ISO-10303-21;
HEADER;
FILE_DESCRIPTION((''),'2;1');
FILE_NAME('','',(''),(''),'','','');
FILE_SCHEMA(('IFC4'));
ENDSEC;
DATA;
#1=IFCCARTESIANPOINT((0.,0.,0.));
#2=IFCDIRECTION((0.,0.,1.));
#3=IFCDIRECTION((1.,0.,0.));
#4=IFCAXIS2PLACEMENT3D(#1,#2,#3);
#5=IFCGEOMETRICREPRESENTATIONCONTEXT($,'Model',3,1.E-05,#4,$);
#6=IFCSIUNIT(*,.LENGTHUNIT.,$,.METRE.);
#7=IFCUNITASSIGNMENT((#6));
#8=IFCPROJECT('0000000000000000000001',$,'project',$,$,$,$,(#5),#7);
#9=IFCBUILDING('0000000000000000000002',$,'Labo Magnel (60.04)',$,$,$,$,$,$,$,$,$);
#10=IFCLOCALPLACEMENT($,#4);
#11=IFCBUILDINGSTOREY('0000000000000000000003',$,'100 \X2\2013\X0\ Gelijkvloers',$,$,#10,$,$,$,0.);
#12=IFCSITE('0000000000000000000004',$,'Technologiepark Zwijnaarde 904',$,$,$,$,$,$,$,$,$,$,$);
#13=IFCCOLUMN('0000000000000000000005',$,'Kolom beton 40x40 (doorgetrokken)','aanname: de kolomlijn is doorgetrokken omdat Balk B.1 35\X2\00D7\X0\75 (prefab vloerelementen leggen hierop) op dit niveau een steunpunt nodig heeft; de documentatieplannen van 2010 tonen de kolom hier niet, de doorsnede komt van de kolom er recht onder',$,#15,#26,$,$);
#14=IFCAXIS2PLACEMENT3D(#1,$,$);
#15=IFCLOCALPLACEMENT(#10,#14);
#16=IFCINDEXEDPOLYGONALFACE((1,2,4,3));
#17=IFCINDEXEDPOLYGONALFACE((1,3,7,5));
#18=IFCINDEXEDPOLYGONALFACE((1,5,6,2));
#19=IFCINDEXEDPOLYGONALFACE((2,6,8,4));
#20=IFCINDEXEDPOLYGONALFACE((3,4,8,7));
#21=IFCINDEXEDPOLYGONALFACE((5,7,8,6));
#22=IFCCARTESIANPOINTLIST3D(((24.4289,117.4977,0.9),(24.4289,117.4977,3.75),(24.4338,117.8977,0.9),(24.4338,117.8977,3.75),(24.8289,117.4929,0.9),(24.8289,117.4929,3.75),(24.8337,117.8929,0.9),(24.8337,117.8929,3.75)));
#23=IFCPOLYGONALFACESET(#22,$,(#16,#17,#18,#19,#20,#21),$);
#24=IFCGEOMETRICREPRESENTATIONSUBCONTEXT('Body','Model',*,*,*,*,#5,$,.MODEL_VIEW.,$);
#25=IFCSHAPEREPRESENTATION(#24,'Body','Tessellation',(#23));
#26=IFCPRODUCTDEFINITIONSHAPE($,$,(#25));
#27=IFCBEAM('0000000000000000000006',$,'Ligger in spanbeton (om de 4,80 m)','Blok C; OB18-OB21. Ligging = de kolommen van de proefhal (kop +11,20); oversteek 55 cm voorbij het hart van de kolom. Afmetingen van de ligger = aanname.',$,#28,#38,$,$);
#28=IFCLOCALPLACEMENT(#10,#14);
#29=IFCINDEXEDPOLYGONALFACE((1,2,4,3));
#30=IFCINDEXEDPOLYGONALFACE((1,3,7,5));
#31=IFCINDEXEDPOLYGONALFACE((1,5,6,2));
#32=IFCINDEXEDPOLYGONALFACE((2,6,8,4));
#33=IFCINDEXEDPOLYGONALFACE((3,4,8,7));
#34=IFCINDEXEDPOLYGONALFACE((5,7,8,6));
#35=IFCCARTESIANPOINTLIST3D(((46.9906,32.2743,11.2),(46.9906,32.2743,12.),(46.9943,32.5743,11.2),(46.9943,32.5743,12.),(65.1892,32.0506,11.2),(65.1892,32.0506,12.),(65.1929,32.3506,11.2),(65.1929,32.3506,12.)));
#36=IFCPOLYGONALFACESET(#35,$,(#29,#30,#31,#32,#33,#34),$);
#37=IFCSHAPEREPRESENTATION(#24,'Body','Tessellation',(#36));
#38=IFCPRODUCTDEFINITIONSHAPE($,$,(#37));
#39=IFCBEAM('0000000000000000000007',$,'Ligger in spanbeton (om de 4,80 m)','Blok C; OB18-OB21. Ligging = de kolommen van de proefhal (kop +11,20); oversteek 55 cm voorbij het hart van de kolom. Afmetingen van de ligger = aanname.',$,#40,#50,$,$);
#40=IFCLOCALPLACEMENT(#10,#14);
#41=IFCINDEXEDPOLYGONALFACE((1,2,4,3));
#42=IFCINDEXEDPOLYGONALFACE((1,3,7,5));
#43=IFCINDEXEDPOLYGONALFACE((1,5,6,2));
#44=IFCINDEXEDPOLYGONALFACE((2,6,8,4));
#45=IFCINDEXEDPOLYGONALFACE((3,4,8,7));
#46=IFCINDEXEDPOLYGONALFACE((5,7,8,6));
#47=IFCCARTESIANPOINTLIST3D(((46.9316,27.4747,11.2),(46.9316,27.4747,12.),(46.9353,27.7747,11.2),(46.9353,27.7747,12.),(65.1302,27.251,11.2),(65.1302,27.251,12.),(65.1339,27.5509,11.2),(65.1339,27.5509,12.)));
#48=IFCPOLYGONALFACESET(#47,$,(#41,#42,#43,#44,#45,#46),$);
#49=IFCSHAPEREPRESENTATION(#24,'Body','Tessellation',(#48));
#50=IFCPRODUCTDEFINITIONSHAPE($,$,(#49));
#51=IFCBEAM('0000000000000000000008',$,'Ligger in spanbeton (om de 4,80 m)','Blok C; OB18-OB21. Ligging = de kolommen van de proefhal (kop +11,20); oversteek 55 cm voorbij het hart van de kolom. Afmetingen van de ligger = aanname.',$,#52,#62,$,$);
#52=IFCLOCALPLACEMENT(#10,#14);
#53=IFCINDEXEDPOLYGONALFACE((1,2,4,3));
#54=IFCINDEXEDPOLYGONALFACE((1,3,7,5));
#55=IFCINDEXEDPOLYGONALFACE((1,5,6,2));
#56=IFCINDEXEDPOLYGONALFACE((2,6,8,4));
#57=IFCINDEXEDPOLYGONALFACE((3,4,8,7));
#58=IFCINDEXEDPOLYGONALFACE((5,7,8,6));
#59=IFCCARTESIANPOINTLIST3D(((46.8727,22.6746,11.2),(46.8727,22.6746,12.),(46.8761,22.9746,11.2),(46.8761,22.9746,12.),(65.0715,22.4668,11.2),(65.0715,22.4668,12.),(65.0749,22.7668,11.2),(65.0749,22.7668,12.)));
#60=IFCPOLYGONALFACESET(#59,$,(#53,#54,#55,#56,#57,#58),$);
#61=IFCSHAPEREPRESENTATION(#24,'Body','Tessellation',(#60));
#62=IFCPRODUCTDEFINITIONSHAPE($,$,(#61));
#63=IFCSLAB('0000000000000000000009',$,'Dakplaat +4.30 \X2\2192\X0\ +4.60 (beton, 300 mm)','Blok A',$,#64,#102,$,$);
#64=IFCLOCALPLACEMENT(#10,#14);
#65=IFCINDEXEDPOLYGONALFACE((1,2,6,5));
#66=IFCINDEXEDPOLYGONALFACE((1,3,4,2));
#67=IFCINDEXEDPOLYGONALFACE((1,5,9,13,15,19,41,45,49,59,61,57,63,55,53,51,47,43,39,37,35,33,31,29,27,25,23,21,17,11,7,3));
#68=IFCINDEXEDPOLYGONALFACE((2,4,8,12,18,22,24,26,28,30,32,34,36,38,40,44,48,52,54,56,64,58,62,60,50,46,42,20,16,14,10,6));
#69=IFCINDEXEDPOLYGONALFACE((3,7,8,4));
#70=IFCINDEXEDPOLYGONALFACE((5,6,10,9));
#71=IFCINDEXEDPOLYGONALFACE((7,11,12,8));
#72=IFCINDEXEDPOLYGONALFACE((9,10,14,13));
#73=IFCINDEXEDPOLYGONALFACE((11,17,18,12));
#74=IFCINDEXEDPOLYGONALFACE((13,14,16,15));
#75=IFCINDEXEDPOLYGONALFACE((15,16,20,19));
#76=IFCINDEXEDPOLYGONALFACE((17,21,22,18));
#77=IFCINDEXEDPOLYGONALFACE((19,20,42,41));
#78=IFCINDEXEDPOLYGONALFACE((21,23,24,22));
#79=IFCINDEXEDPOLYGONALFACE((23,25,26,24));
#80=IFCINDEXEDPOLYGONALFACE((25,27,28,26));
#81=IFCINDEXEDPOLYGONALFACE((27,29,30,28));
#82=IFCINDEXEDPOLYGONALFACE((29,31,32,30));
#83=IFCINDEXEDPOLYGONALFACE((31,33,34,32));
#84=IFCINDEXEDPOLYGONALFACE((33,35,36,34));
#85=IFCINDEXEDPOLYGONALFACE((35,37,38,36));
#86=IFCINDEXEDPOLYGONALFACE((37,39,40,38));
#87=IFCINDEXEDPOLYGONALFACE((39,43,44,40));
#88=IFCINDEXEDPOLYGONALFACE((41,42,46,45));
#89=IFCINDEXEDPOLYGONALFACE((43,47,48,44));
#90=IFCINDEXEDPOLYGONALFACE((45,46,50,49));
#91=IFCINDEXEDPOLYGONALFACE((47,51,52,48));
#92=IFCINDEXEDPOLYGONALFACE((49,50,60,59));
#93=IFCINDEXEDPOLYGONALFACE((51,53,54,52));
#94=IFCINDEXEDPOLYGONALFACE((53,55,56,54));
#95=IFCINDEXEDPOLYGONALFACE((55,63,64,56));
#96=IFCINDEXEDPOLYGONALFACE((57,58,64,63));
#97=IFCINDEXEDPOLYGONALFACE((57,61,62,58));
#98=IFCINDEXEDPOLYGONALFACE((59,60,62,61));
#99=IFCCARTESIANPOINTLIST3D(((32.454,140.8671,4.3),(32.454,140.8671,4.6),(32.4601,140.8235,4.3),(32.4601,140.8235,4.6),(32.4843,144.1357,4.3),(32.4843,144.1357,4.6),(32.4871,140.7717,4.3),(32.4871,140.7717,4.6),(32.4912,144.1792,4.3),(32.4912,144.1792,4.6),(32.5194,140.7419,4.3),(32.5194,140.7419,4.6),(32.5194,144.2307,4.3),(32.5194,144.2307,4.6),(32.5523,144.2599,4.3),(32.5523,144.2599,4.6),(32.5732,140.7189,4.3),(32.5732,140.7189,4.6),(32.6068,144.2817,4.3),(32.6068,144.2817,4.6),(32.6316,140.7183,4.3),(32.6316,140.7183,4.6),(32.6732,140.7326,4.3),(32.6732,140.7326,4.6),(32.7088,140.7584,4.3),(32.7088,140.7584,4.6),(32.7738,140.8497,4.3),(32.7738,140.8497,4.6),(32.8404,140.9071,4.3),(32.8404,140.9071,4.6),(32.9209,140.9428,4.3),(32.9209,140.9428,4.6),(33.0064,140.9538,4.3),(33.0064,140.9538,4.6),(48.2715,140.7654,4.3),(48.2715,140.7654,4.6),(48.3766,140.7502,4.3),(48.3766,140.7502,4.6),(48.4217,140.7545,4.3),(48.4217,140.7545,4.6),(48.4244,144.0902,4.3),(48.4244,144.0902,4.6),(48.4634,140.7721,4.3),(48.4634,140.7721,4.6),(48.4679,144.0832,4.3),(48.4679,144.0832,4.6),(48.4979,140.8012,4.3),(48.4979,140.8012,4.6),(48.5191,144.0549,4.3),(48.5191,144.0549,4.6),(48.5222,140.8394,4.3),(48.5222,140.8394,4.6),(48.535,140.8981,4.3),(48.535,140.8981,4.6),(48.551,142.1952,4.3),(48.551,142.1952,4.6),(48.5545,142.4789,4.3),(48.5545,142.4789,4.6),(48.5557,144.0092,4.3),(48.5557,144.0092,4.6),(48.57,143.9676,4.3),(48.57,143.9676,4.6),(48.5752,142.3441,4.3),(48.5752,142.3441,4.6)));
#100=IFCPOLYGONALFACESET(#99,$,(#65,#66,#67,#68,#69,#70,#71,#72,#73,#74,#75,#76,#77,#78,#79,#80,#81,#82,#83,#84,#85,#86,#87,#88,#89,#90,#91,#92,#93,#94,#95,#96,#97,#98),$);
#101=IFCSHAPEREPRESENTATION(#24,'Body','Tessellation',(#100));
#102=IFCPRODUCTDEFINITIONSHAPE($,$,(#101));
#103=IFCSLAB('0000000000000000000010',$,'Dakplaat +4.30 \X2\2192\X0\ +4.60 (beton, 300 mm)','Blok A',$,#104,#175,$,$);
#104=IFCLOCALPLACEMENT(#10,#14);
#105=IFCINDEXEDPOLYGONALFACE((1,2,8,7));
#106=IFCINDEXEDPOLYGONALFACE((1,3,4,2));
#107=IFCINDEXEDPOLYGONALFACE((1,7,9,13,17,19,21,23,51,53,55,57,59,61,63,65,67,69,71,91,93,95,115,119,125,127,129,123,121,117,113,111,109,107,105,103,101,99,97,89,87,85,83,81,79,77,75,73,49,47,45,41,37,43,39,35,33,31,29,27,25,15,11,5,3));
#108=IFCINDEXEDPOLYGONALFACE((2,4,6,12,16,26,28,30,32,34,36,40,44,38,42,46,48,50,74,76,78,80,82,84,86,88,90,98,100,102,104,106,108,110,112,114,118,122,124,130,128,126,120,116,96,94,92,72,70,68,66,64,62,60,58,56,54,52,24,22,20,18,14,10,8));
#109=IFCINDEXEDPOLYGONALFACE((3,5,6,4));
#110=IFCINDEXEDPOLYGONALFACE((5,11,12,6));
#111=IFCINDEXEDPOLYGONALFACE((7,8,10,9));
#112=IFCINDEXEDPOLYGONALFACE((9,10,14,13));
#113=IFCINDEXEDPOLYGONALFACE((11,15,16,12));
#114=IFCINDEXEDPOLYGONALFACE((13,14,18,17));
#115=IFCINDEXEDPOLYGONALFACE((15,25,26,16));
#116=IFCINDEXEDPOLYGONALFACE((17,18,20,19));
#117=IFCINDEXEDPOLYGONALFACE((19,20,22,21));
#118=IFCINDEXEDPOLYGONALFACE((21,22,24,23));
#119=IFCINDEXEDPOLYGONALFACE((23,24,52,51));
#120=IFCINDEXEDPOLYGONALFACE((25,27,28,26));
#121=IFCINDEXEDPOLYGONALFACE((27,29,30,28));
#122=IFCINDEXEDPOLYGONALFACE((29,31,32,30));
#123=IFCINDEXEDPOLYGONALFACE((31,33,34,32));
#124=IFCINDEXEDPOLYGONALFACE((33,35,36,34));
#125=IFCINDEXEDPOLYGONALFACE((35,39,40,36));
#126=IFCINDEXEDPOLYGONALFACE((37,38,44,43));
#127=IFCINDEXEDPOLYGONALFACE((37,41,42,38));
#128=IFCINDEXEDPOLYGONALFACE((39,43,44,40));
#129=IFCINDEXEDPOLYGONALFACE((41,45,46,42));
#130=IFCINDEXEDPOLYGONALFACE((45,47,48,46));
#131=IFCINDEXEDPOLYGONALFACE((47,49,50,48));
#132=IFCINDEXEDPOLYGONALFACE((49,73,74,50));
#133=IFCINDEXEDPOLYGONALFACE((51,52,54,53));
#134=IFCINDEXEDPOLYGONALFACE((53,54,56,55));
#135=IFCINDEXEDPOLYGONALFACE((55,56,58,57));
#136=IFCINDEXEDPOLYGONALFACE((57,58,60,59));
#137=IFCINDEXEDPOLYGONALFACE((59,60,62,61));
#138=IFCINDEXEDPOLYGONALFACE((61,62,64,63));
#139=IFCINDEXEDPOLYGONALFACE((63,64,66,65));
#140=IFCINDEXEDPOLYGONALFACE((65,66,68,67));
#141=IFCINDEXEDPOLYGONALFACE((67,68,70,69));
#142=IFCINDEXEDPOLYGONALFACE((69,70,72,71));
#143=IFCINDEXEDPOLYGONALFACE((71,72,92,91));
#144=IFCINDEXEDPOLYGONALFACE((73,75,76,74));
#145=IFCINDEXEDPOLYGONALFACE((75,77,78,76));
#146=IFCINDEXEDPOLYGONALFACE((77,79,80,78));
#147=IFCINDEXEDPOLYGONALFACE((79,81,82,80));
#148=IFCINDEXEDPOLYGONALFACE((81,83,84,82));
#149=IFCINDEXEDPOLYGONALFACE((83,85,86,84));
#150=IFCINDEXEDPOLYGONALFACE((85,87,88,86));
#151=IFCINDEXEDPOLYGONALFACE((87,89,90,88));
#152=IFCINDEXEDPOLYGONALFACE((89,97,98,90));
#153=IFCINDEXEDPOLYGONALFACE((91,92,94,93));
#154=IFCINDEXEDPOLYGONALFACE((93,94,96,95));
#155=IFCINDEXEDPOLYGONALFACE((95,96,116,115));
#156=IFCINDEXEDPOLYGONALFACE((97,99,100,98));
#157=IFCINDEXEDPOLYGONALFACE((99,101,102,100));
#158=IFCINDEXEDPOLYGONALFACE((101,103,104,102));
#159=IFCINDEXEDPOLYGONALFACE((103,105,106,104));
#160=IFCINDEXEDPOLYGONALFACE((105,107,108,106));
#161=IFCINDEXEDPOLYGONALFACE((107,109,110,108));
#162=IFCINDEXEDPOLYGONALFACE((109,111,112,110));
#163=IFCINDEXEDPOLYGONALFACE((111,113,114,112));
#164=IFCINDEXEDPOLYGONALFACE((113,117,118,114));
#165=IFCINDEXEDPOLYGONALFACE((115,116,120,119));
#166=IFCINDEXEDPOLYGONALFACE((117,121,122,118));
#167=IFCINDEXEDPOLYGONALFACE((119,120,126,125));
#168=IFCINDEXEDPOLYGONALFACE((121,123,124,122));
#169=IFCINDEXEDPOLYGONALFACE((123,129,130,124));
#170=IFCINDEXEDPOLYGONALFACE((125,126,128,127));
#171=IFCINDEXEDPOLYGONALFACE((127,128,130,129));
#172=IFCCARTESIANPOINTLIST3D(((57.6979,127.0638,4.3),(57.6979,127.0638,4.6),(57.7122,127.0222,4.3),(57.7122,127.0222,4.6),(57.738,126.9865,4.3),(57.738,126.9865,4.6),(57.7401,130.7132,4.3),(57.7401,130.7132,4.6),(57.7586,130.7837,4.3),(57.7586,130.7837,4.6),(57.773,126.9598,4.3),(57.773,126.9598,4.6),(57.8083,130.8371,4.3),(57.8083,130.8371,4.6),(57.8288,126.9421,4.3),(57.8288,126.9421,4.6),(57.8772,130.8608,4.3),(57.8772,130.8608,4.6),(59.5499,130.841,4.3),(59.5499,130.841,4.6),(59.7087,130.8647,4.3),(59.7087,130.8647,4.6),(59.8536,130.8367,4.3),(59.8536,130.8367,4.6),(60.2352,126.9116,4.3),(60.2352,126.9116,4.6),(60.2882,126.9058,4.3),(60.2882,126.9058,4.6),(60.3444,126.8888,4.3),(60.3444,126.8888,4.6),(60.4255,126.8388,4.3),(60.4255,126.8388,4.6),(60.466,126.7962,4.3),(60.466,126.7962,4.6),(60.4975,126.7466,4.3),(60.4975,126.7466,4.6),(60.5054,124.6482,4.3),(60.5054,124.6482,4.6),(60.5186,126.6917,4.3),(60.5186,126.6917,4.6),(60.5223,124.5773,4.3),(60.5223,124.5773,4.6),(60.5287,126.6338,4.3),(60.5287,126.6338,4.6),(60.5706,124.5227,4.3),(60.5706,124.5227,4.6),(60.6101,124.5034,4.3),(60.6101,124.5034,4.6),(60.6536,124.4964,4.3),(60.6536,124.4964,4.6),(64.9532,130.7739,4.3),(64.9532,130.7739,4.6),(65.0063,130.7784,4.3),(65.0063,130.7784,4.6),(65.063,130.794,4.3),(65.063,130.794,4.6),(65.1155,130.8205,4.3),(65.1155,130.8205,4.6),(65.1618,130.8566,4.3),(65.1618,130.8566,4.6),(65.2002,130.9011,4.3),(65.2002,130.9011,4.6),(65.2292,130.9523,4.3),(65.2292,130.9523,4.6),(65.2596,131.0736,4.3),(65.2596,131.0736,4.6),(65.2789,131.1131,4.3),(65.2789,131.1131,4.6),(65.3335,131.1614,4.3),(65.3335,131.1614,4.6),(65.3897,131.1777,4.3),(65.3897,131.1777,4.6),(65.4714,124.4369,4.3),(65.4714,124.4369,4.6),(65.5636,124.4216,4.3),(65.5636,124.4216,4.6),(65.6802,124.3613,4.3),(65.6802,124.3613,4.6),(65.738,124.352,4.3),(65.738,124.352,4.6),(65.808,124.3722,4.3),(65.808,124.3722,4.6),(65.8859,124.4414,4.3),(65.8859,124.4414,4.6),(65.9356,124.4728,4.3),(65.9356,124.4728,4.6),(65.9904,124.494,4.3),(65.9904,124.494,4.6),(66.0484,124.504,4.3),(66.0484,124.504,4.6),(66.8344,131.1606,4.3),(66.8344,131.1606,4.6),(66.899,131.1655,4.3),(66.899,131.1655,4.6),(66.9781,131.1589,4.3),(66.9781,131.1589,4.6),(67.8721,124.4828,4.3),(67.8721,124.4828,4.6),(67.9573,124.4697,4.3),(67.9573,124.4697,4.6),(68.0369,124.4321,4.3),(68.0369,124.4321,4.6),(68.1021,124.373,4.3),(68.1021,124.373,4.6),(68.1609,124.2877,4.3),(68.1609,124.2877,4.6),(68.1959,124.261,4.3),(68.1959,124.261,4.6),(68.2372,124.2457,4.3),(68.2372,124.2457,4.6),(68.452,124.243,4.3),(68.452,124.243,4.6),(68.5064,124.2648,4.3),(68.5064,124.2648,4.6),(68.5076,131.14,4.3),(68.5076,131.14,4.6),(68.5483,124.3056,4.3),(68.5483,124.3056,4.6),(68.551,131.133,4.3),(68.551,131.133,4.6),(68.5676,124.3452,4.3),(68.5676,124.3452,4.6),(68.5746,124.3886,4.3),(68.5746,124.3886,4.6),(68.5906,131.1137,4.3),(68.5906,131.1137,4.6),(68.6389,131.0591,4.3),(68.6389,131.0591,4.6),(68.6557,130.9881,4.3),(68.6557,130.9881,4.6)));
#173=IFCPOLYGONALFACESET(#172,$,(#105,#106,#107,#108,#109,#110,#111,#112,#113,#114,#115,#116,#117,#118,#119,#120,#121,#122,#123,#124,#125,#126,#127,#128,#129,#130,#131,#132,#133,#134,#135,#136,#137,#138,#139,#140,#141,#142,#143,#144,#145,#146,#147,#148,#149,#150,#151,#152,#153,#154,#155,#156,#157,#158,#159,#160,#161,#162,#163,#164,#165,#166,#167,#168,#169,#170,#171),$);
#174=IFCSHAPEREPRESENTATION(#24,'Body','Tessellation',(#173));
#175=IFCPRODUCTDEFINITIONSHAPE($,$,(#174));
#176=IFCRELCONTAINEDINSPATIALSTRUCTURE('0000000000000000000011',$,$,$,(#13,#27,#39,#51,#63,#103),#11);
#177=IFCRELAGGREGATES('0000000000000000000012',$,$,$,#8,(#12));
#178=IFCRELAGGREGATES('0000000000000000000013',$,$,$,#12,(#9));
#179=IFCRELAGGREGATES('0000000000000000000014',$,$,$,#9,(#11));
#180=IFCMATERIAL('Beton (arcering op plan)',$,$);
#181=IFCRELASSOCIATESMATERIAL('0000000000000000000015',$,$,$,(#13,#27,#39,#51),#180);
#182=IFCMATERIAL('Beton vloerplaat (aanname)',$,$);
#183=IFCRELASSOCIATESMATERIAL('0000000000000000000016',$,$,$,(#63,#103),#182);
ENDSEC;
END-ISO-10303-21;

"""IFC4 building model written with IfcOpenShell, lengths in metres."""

from ifc_helpers import new_model, si_unit, frame, origin, origin_with_axes, place, context, subcontext, project, spatial, polyline, outline, extrude, material, element, save


model = new_model("IFC4")

# Units and contexts
model_context = context("Model", 3, precision=1e-05, world=origin_with_axes())
body_context = subcontext(model_context, "Body", "Model", "MODEL_VIEW")
ifc_project = project(units=[si_unit("LENGTHUNIT", "METRE")], contexts=[model_context])

# Site, building, storey
site = spatial("IfcSite", under=ifc_project, Name="Technologiepark Zwijnaarde 904")
building = spatial("IfcBuilding", under=site, Name="Labo Magnel (60.04)")
storey_placement = place(None, origin_with_axes())
storey = spatial("IfcBuildingStorey", under=building, at=storey_placement, Name="100 – Gelijkvloers", Elevation=0.0)

# Column
ifc_material_1 = material(Name="Beton (arcering op plan)")
column_placement = place(storey_placement, frame((0.0, 0.0, 0.9), z_axis=(0.0, 0.0, 1.0), x_axis=(1.0, 0.0, 0.0)))
element("IfcColumn", 1, at=column_placement, inside=storey, material=ifc_material_1, Name="Kolom beton 40x40 (doorgetrokken)", Description="aanname: de kolomlijn is doorgetrokken omdat Balk B.1 35×75 (prefab vloerelementen leggen hierop) op dit niveau een steunpunt nodig heeft; de documentatieplannen van 2010 tonen de kolom hier niet, de doorsnede komt van de kolom er recht onder", context=body_context, shape_type="SweptSolid", body=[
    extrude(outline(polyline([(24.8337, 117.8929), (24.8289, 117.4929), (24.4289, 117.4977), (24.4338, 117.8977), (24.8337, 117.8929)])), origin(), (0.0, 0.0, 1.0), 2.85),
])

# Beams
beam_1_placement = place(storey_placement, frame((46.9924, 32.4243, 11.2), z_axis=(0.0, 0.0, 1.0), x_axis=(0.999924, -0.012293, 0.0)))
element("IfcBeam", 2, at=beam_1_placement, inside=storey, material=ifc_material_1, Name="Ligger in spanbeton (om de 4,80 m)", Description="Blok C; OB18-OB21. Ligging = de kolommen van de proefhal (kop +11,20); oversteek 55 cm voorbij het hart van de kolom. Afmetingen van de ligger = aanname.", context=body_context, shape_type="SweptSolid", body=[
    extrude(outline(polyline([(0.0, -0.15), (18.2, -0.15), (18.2, 0.15), (0.0, 0.15), (0.0, -0.15)])), origin(), (0.0, 0.0, 1.0), 0.8),
])
beam_2_placement = place(storey_placement, frame((46.9334, 27.6247, 11.2), z_axis=(0.0, 0.0, 1.0), x_axis=(0.999924, -0.012293, 0.0)))
element("IfcBeam", 3, at=beam_2_placement, inside=storey, material=ifc_material_1, Name="Ligger in spanbeton (om de 4,80 m)", Description="Blok C; OB18-OB21. Ligging = de kolommen van de proefhal (kop +11,20); oversteek 55 cm voorbij het hart van de kolom. Afmetingen van de ligger = aanname.", context=body_context, shape_type="SweptSolid", body=[
    extrude(outline(polyline([(0.0, -0.15), (18.2, -0.15), (18.2, 0.15), (0.0, 0.15), (0.0, -0.15)])), origin(), (0.0, 0.0, 1.0), 0.8),
])
beam_3_placement = place(storey_placement, frame((46.8744, 22.8246, 11.2), z_axis=(0.0, 0.0, 1.0), x_axis=(0.999935, -0.011416, 0.0)))
element("IfcBeam", 4, at=beam_3_placement, inside=storey, material=ifc_material_1, Name="Ligger in spanbeton (om de 4,80 m)", Description="Blok C; OB18-OB21. Ligging = de kolommen van de proefhal (kop +11,20); oversteek 55 cm voorbij het hart van de kolom. Afmetingen van de ligger = aanname.", context=body_context, shape_type="SweptSolid", body=[
    extrude(outline(polyline([(0.0, -0.15), (18.2, -0.15), (18.2, 0.15), (0.0, 0.15), (0.0, -0.15)])), origin(), (0.0, 0.0, 1.0), 0.8),
])

# Slabs
ifc_material_2 = material(Name="Beton vloerplaat (aanname)")
slab_1_placement = place(storey_placement, frame((0.0, 0.0, 4.3), z_axis=(0.0, 0.0, 1.0), x_axis=(1.0, 0.0, 0.0)))
element("IfcSlab", 5, at=slab_1_placement, inside=storey, material=ifc_material_2, Name="Dakplaat +4.30 → +4.60 (beton, 300 mm)", Description="Blok A", context=body_context, shape_type="SweptSolid", body=[
    extrude(outline(polyline([(32.7738, 140.8497), (32.7088, 140.7584), (32.6732, 140.7326), (32.6316, 140.7183), (32.5732, 140.7189), (32.5194, 140.7419), (32.4871, 140.7717), (32.4601, 140.8235), (32.454, 140.8671), (32.4843, 144.1357), (32.4912, 144.1792), (32.5194, 144.2307), (32.5523, 144.2599), (32.6068, 144.2817), (48.4244, 144.0902), (48.4679, 144.0832), (48.5191, 144.0549), (48.5557, 144.0092), (48.57, 143.9676), (48.5545, 142.4789), (48.5752, 142.3441), (48.551, 142.1952), (48.535, 140.8981), (48.5222, 140.8394), (48.4979, 140.8012), (48.4634, 140.7721), (48.4217, 140.7545), (48.3766, 140.7502), (48.2715, 140.7654), (33.0064, 140.9538), (32.9209, 140.9428), (32.8404, 140.9071), (32.7738, 140.8497)])), origin(), (0.0, 0.0, 1.0), 0.3),
])
slab_2_placement = place(storey_placement, frame((0.0, 0.0, 4.3), z_axis=(0.0, 0.0, 1.0), x_axis=(1.0, 0.0, 0.0)))
element("IfcSlab", 6, at=slab_2_placement, inside=storey, material=ifc_material_2, Name="Dakplaat +4.30 → +4.60 (beton, 300 mm)", Description="Blok A", context=body_context, shape_type="SweptSolid", body=[
    extrude(outline(polyline([(59.5499, 130.841), (59.7087, 130.8647), (59.8536, 130.8367), (64.9532, 130.7739), (65.0063, 130.7784), (65.063, 130.794), (65.1155, 130.8205), (65.1618, 130.8566), (65.2002, 130.9011), (65.2292, 130.9523), (65.2596, 131.0736), (65.2789, 131.1131), (65.3335, 131.1614), (65.3897, 131.1777), (66.8344, 131.1606), (66.899, 131.1655), (66.9781, 131.1589), (68.5076, 131.14), (68.551, 131.133), (68.5906, 131.1137), (68.6389, 131.0591), (68.6557, 130.9881), (68.5746, 124.3886), (68.5676, 124.3452), (68.5483, 124.3056), (68.5064, 124.2648), (68.452, 124.243), (68.2372, 124.2457), (68.1959, 124.261), (68.1609, 124.2877), (68.1021, 124.373), (68.0369, 124.4321), (67.9573, 124.4697), (67.8721, 124.4828), (66.0484, 124.504), (65.9904, 124.494), (65.9356, 124.4728), (65.8859, 124.4414), (65.808, 124.3722), (65.738, 124.352), (65.6802, 124.3613), (65.5636, 124.4216), (65.4714, 124.4369), (60.6536, 124.4964), (60.6101, 124.5034), (60.5706, 124.5227), (60.5223, 124.5773), (60.5054, 124.6482), (60.5287, 126.6338), (60.5186, 126.6917), (60.4975, 126.7466), (60.466, 126.7962), (60.4255, 126.8388), (60.3444, 126.8888), (60.2882, 126.9058), (60.2352, 126.9116), (57.8288, 126.9421), (57.773, 126.9598), (57.738, 126.9865), (57.7122, 127.0222), (57.6979, 127.0638), (57.7401, 130.7132), (57.7586, 130.7837), (57.8083, 130.8371), (57.8772, 130.8608), (59.5499, 130.841)])), origin(), (0.0, 0.0, 1.0), 0.3),
])

save(model, "model.ifc")
